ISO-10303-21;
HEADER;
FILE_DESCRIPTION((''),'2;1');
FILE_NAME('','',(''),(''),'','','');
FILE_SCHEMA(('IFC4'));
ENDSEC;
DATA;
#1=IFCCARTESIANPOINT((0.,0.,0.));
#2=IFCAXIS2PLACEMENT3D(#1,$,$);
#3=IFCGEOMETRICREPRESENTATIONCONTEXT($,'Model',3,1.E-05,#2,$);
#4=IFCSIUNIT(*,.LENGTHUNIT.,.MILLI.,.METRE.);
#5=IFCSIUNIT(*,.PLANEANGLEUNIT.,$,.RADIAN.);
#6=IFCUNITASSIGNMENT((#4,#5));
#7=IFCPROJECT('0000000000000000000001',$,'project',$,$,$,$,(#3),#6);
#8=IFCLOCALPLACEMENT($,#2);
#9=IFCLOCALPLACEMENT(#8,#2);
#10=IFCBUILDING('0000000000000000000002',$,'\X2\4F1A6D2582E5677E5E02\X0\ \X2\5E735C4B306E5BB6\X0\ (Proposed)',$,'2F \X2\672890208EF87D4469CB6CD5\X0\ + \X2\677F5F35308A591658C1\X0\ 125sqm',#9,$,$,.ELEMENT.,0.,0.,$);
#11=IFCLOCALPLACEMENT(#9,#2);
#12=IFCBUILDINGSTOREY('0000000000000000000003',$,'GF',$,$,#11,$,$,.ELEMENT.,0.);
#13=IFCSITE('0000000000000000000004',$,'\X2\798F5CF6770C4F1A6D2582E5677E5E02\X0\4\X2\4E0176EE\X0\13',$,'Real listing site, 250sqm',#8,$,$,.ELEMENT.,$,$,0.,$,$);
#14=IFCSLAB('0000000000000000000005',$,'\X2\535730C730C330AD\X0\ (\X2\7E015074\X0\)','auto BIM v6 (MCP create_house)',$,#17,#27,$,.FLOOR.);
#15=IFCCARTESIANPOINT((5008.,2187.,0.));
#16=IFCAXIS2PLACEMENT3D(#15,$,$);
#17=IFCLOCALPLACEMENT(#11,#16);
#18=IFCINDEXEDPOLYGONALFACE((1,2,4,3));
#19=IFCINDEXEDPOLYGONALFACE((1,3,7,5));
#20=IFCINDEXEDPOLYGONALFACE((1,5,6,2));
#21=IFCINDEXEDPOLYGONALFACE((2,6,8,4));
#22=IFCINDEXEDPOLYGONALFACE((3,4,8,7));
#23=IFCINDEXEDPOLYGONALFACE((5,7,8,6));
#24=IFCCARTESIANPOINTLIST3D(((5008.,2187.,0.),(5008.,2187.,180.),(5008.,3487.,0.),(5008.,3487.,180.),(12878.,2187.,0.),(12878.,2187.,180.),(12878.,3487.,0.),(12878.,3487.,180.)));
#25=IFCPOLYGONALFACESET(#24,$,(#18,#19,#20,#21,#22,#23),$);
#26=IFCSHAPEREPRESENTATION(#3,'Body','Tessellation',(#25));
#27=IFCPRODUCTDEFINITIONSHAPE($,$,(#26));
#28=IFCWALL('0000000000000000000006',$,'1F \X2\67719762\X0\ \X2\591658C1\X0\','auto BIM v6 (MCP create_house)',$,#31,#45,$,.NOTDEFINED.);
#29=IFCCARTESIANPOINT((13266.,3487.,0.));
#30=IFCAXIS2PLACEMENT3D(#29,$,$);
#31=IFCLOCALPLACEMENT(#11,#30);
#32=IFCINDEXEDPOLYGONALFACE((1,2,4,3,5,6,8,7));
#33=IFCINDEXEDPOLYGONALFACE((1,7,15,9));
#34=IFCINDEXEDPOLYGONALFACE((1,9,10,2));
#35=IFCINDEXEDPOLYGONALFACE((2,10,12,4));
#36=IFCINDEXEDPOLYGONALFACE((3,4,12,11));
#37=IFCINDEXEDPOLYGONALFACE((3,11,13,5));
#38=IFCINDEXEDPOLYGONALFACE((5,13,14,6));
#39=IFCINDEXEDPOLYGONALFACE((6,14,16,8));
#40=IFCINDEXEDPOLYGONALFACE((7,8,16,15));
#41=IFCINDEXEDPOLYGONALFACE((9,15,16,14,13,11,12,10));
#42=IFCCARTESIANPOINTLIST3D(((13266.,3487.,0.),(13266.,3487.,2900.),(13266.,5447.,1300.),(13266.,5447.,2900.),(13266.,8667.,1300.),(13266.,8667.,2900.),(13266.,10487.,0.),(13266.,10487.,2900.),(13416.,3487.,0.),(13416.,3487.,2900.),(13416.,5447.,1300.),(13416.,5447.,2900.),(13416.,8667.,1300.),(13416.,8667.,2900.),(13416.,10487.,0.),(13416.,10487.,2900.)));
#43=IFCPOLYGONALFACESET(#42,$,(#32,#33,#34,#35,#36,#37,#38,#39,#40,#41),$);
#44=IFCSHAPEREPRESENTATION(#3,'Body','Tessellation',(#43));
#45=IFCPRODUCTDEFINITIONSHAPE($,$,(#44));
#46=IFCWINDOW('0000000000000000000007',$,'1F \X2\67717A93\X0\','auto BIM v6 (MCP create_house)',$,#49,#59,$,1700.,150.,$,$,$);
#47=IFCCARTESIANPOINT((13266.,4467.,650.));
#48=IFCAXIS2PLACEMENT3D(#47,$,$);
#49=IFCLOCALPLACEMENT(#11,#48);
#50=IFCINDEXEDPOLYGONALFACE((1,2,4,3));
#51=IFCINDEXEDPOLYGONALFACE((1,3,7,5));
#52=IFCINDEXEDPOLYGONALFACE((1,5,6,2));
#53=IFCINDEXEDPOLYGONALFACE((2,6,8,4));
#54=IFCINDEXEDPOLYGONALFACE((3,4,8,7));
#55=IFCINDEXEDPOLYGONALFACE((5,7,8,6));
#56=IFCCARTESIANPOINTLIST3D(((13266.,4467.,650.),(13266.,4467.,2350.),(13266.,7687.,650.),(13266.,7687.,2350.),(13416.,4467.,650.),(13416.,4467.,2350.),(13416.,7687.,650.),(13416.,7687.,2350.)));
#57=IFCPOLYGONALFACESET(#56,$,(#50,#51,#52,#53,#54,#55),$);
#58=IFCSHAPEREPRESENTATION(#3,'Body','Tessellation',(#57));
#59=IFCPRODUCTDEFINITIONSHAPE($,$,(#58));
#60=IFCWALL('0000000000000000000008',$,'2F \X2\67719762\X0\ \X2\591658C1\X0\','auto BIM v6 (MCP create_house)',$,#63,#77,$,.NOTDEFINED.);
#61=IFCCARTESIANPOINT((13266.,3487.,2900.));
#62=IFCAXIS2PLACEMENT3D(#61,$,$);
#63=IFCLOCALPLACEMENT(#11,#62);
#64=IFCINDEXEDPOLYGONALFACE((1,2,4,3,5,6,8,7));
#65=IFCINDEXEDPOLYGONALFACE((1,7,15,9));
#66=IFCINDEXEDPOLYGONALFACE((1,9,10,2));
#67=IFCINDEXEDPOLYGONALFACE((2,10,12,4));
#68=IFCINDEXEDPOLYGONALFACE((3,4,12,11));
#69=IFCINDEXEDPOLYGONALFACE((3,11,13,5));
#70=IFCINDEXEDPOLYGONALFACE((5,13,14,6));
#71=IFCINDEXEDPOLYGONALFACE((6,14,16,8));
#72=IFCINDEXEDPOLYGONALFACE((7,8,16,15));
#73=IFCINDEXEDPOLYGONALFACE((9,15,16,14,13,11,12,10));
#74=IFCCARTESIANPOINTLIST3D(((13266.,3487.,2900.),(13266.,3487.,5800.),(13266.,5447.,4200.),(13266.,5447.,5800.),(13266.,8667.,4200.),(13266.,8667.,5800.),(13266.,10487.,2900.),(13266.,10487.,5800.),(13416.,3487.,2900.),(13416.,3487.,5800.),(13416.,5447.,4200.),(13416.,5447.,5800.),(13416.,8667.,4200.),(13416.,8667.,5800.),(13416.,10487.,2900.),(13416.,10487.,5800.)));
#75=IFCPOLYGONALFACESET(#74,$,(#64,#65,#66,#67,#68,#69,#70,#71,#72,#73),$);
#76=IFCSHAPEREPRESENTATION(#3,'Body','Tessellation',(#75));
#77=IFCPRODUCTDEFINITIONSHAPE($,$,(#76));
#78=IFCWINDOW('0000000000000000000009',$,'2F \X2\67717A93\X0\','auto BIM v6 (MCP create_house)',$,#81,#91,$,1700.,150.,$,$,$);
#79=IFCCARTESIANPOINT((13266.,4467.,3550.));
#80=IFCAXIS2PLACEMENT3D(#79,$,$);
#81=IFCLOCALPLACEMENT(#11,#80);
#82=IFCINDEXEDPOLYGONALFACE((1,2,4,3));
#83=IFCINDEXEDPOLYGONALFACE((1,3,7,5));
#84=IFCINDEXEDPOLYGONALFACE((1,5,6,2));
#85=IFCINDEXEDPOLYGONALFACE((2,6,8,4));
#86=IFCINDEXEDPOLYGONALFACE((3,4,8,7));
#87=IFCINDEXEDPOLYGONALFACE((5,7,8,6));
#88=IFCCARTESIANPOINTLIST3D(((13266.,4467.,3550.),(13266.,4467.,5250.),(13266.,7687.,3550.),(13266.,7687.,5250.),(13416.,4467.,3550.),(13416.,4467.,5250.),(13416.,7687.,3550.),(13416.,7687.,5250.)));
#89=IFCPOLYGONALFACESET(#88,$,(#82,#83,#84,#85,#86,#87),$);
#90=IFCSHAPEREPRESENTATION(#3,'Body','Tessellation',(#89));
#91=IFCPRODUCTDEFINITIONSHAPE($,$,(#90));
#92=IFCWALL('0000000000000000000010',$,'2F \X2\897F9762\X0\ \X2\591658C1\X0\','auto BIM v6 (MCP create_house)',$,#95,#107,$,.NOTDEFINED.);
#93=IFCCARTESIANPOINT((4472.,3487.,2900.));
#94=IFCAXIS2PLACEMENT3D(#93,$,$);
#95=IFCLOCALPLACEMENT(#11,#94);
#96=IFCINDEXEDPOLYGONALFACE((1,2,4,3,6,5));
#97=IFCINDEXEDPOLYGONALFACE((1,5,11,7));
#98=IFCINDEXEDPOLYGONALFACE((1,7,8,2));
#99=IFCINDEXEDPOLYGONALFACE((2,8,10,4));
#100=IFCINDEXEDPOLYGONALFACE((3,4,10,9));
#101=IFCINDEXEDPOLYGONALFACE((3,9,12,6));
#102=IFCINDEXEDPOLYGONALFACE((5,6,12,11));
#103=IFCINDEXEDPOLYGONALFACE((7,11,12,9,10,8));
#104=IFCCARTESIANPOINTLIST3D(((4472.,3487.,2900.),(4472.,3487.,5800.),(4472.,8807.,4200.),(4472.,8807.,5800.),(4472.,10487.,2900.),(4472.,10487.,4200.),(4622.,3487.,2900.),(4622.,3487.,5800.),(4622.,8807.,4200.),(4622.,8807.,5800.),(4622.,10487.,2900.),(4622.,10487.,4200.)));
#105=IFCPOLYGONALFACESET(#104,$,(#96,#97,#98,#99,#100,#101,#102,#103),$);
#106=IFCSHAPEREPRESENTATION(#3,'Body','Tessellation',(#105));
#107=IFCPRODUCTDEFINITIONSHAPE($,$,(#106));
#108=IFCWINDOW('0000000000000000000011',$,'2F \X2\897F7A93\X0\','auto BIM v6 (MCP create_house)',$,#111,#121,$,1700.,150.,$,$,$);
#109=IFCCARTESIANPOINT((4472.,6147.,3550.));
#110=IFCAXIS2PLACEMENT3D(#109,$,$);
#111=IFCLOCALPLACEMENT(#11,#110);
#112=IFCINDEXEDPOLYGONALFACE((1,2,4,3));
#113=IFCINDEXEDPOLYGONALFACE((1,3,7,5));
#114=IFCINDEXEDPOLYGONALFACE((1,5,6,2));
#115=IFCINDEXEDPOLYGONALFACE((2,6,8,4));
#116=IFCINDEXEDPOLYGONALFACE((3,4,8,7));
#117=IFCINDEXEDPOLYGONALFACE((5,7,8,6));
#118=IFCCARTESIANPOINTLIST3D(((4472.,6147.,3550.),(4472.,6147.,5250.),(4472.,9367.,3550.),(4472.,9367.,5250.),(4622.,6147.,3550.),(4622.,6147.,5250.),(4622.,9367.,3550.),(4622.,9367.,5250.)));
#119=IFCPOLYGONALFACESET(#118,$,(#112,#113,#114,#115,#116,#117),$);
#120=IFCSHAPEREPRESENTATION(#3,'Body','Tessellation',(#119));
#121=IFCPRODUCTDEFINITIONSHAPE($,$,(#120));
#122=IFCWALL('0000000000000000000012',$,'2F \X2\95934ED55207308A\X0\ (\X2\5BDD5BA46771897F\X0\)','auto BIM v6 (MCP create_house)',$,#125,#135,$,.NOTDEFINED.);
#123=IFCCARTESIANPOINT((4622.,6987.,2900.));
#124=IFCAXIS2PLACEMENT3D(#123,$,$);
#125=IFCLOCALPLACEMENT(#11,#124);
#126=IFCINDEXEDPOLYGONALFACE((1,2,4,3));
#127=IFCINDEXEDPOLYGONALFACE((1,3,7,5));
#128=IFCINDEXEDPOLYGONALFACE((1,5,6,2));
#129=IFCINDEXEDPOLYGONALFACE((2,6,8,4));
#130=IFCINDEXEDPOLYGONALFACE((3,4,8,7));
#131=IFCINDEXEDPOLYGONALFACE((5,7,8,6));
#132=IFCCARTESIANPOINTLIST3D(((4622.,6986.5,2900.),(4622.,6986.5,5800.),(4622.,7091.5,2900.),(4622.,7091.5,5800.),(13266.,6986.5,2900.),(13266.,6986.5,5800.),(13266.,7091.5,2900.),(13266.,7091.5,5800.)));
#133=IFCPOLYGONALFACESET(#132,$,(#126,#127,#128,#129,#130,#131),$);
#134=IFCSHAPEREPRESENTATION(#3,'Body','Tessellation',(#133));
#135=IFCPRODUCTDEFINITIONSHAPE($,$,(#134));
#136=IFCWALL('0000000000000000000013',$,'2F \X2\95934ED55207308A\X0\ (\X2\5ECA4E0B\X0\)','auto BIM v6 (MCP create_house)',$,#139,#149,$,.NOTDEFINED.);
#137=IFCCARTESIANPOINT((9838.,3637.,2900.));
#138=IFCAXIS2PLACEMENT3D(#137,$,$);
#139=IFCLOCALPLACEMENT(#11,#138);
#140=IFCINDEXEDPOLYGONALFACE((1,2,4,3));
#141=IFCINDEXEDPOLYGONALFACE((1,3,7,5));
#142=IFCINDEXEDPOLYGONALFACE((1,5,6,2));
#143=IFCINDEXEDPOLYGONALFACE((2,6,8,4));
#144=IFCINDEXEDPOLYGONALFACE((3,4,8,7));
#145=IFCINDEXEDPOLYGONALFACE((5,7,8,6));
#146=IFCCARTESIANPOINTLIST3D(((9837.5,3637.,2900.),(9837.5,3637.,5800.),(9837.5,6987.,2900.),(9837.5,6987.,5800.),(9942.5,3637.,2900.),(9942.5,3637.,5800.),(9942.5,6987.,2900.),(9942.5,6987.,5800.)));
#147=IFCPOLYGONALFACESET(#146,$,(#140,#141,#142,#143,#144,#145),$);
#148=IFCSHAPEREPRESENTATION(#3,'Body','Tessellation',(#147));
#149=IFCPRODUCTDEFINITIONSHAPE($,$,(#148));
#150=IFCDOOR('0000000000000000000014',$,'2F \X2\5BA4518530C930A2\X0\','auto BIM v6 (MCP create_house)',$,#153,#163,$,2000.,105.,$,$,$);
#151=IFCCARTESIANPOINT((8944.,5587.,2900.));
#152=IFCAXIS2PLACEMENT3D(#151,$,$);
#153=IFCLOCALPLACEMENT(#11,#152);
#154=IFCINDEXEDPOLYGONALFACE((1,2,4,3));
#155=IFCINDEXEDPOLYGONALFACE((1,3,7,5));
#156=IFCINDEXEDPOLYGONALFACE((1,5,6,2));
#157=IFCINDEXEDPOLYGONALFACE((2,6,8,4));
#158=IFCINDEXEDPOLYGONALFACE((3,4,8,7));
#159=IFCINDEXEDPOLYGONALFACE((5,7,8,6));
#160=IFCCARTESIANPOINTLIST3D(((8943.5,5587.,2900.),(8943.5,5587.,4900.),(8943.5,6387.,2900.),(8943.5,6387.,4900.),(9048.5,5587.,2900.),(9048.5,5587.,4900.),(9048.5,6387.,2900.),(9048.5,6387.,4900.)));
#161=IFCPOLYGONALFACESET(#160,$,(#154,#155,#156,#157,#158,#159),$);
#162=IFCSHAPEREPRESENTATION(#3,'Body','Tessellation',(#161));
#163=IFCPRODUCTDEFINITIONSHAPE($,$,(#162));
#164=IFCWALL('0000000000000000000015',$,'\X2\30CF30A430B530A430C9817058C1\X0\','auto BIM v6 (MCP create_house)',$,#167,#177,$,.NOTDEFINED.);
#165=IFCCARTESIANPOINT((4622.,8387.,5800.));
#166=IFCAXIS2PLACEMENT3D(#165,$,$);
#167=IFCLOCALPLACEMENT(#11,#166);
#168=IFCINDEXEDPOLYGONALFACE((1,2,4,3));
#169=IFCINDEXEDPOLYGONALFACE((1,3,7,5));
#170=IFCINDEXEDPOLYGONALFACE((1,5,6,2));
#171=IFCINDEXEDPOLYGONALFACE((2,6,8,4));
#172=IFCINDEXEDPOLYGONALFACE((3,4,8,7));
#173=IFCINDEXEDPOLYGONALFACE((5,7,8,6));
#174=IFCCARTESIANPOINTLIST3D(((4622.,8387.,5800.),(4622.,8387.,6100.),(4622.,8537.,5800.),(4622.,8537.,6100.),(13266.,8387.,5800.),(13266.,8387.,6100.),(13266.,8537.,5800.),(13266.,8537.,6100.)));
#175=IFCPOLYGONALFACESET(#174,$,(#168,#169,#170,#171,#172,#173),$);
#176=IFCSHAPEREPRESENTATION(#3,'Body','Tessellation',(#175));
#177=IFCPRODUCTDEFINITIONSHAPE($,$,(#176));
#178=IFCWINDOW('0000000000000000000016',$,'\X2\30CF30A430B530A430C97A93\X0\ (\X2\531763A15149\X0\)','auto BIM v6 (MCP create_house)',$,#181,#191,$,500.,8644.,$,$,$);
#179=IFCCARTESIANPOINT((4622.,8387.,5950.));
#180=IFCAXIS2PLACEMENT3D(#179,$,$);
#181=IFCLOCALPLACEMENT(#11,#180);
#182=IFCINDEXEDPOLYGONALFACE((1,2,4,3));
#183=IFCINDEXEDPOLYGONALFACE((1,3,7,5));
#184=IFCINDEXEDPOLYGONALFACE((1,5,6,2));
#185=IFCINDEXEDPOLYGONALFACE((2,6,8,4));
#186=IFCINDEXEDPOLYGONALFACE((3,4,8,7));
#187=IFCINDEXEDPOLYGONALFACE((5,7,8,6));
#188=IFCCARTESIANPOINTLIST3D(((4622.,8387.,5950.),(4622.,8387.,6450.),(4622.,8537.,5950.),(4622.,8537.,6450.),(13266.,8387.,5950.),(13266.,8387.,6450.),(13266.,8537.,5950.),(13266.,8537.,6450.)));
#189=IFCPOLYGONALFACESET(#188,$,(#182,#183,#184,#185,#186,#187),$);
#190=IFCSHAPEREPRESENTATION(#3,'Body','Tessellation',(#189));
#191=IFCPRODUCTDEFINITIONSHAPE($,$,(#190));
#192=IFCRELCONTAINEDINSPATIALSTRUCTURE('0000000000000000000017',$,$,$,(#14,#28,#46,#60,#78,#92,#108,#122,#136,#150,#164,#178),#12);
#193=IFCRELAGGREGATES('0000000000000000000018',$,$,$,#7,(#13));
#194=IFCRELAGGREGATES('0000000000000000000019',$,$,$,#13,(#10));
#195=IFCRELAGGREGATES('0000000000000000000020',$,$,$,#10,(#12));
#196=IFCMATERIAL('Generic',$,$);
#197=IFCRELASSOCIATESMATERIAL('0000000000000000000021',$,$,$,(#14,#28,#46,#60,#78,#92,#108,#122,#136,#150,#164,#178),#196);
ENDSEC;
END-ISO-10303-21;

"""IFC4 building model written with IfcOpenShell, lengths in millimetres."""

from ifc_helpers import new_model, si_unit, frame, frame_2d, origin, place, context, project, spatial, rectangle, extrude, material, element, fill, save


model = new_model("IFC4")

# Units and contexts
model_context = context("Model", 3, precision=1e-05, world=origin())
ifc_project = project(units=[si_unit("LENGTHUNIT", "METRE", prefix="MILLI"), si_unit("PLANEANGLEUNIT", "RADIAN")], contexts=[model_context])

# Site, building, storey
site_placement = place(None, origin())
site = spatial("IfcSite", under=ifc_project, at=site_placement, Name="福島県会津若松市4丁目13", ObjectType="Real listing site, 250sqm", CompositionType="ELEMENT", RefElevation=0.0)
building_placement = place(site_placement, origin())
building = spatial("IfcBuilding", under=site, at=building_placement, Name="会津若松市 平屋の家 (Proposed)", ObjectType="2F 木造軸組構法 + 板張り外壁 125sqm", CompositionType="ELEMENT", ElevationOfRefHeight=0.0, ElevationOfTerrain=0.0)
storey_placement = place(building_placement, origin())
storey = spatial("IfcBuildingStorey", under=building, at=storey_placement, Name="GF", CompositionType="ELEMENT", Elevation=0.0)

# Slab
ifc_material = material(Name="Generic")
slab_placement = place(storey_placement, frame((5008.0, 2187.0, 0.0)))
element("IfcSlab", 1, at=slab_placement, inside=storey, material=ifc_material, Name="南デッキ (縁側)", Description="auto BIM v6 (MCP create_house)", PredefinedType="FLOOR", context=model_context, shape_type="SweptSolid", body=[
    extrude(rectangle(XDim=7870.0, YDim=1300.0, at=frame_2d((3935.0, 650.0))), frame((5008.0, 2187.0, 0.0)), (0.0, 0.0, 1.0), 180.0),
])

# Wall, opening, window
wall_1_placement = place(storey_placement, frame((13266.0, 3487.0, 0.0)))
wall_1 = element("IfcWall", 2, at=wall_1_placement, inside=storey, material=ifc_material, Name="1F 東面 外壁", Description="auto BIM v6 (MCP create_house)", PredefinedType="NOTDEFINED", context=model_context, shape_type="SweptSolid", body=[
    extrude(rectangle(XDim=150.0, YDim=7000.0, at=frame_2d((75.0, 3500.0))), frame((13266.0, 3487.0, 0.0)), (0.0, 0.0, 1.0), 2900.0),
])
opening_1_placement = place(storey_placement, frame((13266.0, 4467.0, 650.0)))
opening_1 = element("IfcOpeningElement", 3, at=opening_1_placement, cuts=wall_1, PredefinedType="NOTDEFINED", context=model_context, shape_type="SweptSolid", body=[
    extrude(rectangle(XDim=150.0, YDim=3220.0, at=frame_2d((75.0, 1610.0))), frame((13266.0, 4467.0, 650.0)), (0.0, 0.0, 1.0), 1700.0),
])
window_1_placement = place(storey_placement, frame((13266.0, 4467.0, 650.0)))
window_1 = element("IfcWindow", 4, at=window_1_placement, inside=storey, material=ifc_material, Name="1F 東窓", Description="auto BIM v6 (MCP create_house)", OverallHeight=1700.0, OverallWidth=150.0, context=model_context, shape_type="SweptSolid", body=[
    extrude(rectangle(XDim=150.0, YDim=3220.0, at=frame_2d((75.0, 1610.0))), frame((13266.0, 4467.0, 650.0)), (0.0, 0.0, 1.0), 1700.0),
])
fill(opening_1, window_1)

# Walls, openings, windows
wall_2_placement = place(storey_placement, frame((13266.0, 3487.0, 2900.0)))
wall_2 = element("IfcWall", 5, at=wall_2_placement, inside=storey, material=ifc_material, Name="2F 東面 外壁", Description="auto BIM v6 (MCP create_house)", PredefinedType="NOTDEFINED", context=model_context, shape_type="SweptSolid", body=[
    extrude(rectangle(XDim=150.0, YDim=7000.0, at=frame_2d((75.0, 3500.0))), frame((13266.0, 3487.0, 2900.0)), (0.0, 0.0, 1.0), 2900.0),
])
opening_2_placement = place(storey_placement, frame((13266.0, 4467.0, 3550.0)))
opening_2 = element("IfcOpeningElement", 6, at=opening_2_placement, cuts=wall_2, PredefinedType="NOTDEFINED", context=model_context, shape_type="SweptSolid", body=[
    extrude(rectangle(XDim=150.0, YDim=3220.0, at=frame_2d((75.0, 1610.0))), frame((13266.0, 4467.0, 3550.0)), (0.0, 0.0, 1.0), 1700.0),
])
window_2_placement = place(storey_placement, frame((13266.0, 4467.0, 3550.0)))
window_2 = element("IfcWindow", 7, at=window_2_placement, inside=storey, material=ifc_material, Name="2F 東窓", Description="auto BIM v6 (MCP create_house)", OverallHeight=1700.0, OverallWidth=150.0, context=model_context, shape_type="SweptSolid", body=[
    extrude(rectangle(XDim=150.0, YDim=3220.0, at=frame_2d((75.0, 1610.0))), frame((13266.0, 4467.0, 3550.0)), (0.0, 0.0, 1.0), 1700.0),
])
fill(opening_2, window_2)
wall_3_placement = place(storey_placement, frame((4472.0, 3487.0, 2900.0)))
wall_3 = element("IfcWall", 8, at=wall_3_placement, inside=storey, material=ifc_material, Name="2F 西面 外壁", Description="auto BIM v6 (MCP create_house)", PredefinedType="NOTDEFINED", context=model_context, shape_type="SweptSolid", body=[
    extrude(rectangle(XDim=150.0, YDim=7000.0, at=frame_2d((75.0, 3500.0))), frame((4472.0, 3487.0, 2900.0)), (0.0, 0.0, 1.0), 2900.0),
])
opening_3_placement = place(storey_placement, frame((4472.0, 6147.0, 3550.0)))
opening_3 = element("IfcOpeningElement", 9, at=opening_3_placement, cuts=wall_3, PredefinedType="NOTDEFINED", context=model_context, shape_type="SweptSolid", body=[
    extrude(rectangle(XDim=150.0, YDim=3220.0, at=frame_2d((75.0, 1610.0))), frame((4472.0, 6147.0, 3550.0)), (0.0, 0.0, 1.0), 1700.0),
])
window_3_placement = place(storey_placement, frame((4472.0, 6147.0, 3550.0)))
window_3 = element("IfcWindow", 10, at=window_3_placement, inside=storey, material=ifc_material, Name="2F 西窓", Description="auto BIM v6 (MCP create_house)", OverallHeight=1700.0, OverallWidth=150.0, context=model_context, shape_type="SweptSolid", body=[
    extrude(rectangle(XDim=150.0, YDim=3220.0, at=frame_2d((75.0, 1610.0))), frame((4472.0, 6147.0, 3550.0)), (0.0, 0.0, 1.0), 1700.0),
])
fill(opening_3, window_3)

# Walls
wall_4_placement = place(storey_placement, frame((4622.0, 6987.0, 2900.0)))
element("IfcWall", 11, at=wall_4_placement, inside=storey, material=ifc_material, Name="2F 間仕切り (寝室東西)", Description="auto BIM v6 (MCP create_house)", PredefinedType="NOTDEFINED", context=model_context, shape_type="SweptSolid", body=[
    extrude(rectangle(XDim=8644.0, YDim=105.0, at=frame_2d((4322.0, 52.0))), frame((4622.0, 6987.0, 2900.0)), (0.0, 0.0, 1.0), 2900.0),
])
wall_5_placement = place(storey_placement, frame((9838.0, 3637.0, 2900.0)))
element("IfcWall", 12, at=wall_5_placement, inside=storey, material=ifc_material, Name="2F 間仕切り (廊下)", Description="auto BIM v6 (MCP create_house)", PredefinedType="NOTDEFINED", context=model_context, shape_type="SweptSolid", body=[
    extrude(rectangle(XDim=105.0, YDim=3350.0, at=frame_2d((52.0, 1675.0))), frame((9838.0, 3637.0, 2900.0)), (0.0, 0.0, 1.0), 2900.0),
])

# Door
door_placement = place(storey_placement, frame((8944.0, 5587.0, 2900.0)))
element("IfcDoor", 13, at=door_placement, inside=storey, material=ifc_material, Name="2F 室内ドア", Description="auto BIM v6 (MCP create_house)", OverallHeight=2000.0, OverallWidth=105.0, context=model_context, shape_type="SweptSolid", body=[
    extrude(rectangle(XDim=105.0, YDim=800.0, at=frame_2d((52.0, 400.0))), frame((8944.0, 5587.0, 2900.0)), (0.0, 0.0, 1.0), 2000.0),
])

# Wall, opening, window
wall_6_placement = place(storey_placement, frame((4622.0, 8387.0, 5800.0)))
wall_6 = element("IfcWall", 14, at=wall_6_placement, inside=storey, material=ifc_material, Name="ハイサイド腰壁", Description="auto BIM v6 (MCP create_house)", PredefinedType="NOTDEFINED", context=model_context, shape_type="SweptSolid", body=[
    extrude(rectangle(XDim=8644.0, YDim=150.0, at=frame_2d((4322.0, 75.0))), frame((4622.0, 8387.0, 5800.0)), (0.0, 0.0, 1.0), 700.0),
])
opening_4_placement = place(storey_placement, frame((4622.0, 8387.0, 5950.0)))
opening_4 = element("IfcOpeningElement", 15, at=opening_4_placement, cuts=wall_6, PredefinedType="NOTDEFINED", context=model_context, shape_type="SweptSolid", body=[
    extrude(rectangle(XDim=8644.0, YDim=150.0, at=frame_2d((4322.0, 75.0))), frame((4622.0, 8387.0, 5950.0)), (0.0, 0.0, 1.0), 500.0),
])
window_4_placement = place(storey_placement, frame((4622.0, 8387.0, 5950.0)))
window_4 = element("IfcWindow", 16, at=window_4_placement, inside=storey, material=ifc_material, Name="ハイサイド窓 (北採光)", Description="auto BIM v6 (MCP create_house)", OverallHeight=500.0, OverallWidth=8644.0, context=model_context, shape_type="SweptSolid", body=[
    extrude(rectangle(XDim=8644.0, YDim=150.0, at=frame_2d((4322.0, 75.0))), frame((4622.0, 8387.0, 5950.0)), (0.0, 0.0, 1.0), 500.0),
])
fill(opening_4, window_4)

save(model, "model.ifc")
